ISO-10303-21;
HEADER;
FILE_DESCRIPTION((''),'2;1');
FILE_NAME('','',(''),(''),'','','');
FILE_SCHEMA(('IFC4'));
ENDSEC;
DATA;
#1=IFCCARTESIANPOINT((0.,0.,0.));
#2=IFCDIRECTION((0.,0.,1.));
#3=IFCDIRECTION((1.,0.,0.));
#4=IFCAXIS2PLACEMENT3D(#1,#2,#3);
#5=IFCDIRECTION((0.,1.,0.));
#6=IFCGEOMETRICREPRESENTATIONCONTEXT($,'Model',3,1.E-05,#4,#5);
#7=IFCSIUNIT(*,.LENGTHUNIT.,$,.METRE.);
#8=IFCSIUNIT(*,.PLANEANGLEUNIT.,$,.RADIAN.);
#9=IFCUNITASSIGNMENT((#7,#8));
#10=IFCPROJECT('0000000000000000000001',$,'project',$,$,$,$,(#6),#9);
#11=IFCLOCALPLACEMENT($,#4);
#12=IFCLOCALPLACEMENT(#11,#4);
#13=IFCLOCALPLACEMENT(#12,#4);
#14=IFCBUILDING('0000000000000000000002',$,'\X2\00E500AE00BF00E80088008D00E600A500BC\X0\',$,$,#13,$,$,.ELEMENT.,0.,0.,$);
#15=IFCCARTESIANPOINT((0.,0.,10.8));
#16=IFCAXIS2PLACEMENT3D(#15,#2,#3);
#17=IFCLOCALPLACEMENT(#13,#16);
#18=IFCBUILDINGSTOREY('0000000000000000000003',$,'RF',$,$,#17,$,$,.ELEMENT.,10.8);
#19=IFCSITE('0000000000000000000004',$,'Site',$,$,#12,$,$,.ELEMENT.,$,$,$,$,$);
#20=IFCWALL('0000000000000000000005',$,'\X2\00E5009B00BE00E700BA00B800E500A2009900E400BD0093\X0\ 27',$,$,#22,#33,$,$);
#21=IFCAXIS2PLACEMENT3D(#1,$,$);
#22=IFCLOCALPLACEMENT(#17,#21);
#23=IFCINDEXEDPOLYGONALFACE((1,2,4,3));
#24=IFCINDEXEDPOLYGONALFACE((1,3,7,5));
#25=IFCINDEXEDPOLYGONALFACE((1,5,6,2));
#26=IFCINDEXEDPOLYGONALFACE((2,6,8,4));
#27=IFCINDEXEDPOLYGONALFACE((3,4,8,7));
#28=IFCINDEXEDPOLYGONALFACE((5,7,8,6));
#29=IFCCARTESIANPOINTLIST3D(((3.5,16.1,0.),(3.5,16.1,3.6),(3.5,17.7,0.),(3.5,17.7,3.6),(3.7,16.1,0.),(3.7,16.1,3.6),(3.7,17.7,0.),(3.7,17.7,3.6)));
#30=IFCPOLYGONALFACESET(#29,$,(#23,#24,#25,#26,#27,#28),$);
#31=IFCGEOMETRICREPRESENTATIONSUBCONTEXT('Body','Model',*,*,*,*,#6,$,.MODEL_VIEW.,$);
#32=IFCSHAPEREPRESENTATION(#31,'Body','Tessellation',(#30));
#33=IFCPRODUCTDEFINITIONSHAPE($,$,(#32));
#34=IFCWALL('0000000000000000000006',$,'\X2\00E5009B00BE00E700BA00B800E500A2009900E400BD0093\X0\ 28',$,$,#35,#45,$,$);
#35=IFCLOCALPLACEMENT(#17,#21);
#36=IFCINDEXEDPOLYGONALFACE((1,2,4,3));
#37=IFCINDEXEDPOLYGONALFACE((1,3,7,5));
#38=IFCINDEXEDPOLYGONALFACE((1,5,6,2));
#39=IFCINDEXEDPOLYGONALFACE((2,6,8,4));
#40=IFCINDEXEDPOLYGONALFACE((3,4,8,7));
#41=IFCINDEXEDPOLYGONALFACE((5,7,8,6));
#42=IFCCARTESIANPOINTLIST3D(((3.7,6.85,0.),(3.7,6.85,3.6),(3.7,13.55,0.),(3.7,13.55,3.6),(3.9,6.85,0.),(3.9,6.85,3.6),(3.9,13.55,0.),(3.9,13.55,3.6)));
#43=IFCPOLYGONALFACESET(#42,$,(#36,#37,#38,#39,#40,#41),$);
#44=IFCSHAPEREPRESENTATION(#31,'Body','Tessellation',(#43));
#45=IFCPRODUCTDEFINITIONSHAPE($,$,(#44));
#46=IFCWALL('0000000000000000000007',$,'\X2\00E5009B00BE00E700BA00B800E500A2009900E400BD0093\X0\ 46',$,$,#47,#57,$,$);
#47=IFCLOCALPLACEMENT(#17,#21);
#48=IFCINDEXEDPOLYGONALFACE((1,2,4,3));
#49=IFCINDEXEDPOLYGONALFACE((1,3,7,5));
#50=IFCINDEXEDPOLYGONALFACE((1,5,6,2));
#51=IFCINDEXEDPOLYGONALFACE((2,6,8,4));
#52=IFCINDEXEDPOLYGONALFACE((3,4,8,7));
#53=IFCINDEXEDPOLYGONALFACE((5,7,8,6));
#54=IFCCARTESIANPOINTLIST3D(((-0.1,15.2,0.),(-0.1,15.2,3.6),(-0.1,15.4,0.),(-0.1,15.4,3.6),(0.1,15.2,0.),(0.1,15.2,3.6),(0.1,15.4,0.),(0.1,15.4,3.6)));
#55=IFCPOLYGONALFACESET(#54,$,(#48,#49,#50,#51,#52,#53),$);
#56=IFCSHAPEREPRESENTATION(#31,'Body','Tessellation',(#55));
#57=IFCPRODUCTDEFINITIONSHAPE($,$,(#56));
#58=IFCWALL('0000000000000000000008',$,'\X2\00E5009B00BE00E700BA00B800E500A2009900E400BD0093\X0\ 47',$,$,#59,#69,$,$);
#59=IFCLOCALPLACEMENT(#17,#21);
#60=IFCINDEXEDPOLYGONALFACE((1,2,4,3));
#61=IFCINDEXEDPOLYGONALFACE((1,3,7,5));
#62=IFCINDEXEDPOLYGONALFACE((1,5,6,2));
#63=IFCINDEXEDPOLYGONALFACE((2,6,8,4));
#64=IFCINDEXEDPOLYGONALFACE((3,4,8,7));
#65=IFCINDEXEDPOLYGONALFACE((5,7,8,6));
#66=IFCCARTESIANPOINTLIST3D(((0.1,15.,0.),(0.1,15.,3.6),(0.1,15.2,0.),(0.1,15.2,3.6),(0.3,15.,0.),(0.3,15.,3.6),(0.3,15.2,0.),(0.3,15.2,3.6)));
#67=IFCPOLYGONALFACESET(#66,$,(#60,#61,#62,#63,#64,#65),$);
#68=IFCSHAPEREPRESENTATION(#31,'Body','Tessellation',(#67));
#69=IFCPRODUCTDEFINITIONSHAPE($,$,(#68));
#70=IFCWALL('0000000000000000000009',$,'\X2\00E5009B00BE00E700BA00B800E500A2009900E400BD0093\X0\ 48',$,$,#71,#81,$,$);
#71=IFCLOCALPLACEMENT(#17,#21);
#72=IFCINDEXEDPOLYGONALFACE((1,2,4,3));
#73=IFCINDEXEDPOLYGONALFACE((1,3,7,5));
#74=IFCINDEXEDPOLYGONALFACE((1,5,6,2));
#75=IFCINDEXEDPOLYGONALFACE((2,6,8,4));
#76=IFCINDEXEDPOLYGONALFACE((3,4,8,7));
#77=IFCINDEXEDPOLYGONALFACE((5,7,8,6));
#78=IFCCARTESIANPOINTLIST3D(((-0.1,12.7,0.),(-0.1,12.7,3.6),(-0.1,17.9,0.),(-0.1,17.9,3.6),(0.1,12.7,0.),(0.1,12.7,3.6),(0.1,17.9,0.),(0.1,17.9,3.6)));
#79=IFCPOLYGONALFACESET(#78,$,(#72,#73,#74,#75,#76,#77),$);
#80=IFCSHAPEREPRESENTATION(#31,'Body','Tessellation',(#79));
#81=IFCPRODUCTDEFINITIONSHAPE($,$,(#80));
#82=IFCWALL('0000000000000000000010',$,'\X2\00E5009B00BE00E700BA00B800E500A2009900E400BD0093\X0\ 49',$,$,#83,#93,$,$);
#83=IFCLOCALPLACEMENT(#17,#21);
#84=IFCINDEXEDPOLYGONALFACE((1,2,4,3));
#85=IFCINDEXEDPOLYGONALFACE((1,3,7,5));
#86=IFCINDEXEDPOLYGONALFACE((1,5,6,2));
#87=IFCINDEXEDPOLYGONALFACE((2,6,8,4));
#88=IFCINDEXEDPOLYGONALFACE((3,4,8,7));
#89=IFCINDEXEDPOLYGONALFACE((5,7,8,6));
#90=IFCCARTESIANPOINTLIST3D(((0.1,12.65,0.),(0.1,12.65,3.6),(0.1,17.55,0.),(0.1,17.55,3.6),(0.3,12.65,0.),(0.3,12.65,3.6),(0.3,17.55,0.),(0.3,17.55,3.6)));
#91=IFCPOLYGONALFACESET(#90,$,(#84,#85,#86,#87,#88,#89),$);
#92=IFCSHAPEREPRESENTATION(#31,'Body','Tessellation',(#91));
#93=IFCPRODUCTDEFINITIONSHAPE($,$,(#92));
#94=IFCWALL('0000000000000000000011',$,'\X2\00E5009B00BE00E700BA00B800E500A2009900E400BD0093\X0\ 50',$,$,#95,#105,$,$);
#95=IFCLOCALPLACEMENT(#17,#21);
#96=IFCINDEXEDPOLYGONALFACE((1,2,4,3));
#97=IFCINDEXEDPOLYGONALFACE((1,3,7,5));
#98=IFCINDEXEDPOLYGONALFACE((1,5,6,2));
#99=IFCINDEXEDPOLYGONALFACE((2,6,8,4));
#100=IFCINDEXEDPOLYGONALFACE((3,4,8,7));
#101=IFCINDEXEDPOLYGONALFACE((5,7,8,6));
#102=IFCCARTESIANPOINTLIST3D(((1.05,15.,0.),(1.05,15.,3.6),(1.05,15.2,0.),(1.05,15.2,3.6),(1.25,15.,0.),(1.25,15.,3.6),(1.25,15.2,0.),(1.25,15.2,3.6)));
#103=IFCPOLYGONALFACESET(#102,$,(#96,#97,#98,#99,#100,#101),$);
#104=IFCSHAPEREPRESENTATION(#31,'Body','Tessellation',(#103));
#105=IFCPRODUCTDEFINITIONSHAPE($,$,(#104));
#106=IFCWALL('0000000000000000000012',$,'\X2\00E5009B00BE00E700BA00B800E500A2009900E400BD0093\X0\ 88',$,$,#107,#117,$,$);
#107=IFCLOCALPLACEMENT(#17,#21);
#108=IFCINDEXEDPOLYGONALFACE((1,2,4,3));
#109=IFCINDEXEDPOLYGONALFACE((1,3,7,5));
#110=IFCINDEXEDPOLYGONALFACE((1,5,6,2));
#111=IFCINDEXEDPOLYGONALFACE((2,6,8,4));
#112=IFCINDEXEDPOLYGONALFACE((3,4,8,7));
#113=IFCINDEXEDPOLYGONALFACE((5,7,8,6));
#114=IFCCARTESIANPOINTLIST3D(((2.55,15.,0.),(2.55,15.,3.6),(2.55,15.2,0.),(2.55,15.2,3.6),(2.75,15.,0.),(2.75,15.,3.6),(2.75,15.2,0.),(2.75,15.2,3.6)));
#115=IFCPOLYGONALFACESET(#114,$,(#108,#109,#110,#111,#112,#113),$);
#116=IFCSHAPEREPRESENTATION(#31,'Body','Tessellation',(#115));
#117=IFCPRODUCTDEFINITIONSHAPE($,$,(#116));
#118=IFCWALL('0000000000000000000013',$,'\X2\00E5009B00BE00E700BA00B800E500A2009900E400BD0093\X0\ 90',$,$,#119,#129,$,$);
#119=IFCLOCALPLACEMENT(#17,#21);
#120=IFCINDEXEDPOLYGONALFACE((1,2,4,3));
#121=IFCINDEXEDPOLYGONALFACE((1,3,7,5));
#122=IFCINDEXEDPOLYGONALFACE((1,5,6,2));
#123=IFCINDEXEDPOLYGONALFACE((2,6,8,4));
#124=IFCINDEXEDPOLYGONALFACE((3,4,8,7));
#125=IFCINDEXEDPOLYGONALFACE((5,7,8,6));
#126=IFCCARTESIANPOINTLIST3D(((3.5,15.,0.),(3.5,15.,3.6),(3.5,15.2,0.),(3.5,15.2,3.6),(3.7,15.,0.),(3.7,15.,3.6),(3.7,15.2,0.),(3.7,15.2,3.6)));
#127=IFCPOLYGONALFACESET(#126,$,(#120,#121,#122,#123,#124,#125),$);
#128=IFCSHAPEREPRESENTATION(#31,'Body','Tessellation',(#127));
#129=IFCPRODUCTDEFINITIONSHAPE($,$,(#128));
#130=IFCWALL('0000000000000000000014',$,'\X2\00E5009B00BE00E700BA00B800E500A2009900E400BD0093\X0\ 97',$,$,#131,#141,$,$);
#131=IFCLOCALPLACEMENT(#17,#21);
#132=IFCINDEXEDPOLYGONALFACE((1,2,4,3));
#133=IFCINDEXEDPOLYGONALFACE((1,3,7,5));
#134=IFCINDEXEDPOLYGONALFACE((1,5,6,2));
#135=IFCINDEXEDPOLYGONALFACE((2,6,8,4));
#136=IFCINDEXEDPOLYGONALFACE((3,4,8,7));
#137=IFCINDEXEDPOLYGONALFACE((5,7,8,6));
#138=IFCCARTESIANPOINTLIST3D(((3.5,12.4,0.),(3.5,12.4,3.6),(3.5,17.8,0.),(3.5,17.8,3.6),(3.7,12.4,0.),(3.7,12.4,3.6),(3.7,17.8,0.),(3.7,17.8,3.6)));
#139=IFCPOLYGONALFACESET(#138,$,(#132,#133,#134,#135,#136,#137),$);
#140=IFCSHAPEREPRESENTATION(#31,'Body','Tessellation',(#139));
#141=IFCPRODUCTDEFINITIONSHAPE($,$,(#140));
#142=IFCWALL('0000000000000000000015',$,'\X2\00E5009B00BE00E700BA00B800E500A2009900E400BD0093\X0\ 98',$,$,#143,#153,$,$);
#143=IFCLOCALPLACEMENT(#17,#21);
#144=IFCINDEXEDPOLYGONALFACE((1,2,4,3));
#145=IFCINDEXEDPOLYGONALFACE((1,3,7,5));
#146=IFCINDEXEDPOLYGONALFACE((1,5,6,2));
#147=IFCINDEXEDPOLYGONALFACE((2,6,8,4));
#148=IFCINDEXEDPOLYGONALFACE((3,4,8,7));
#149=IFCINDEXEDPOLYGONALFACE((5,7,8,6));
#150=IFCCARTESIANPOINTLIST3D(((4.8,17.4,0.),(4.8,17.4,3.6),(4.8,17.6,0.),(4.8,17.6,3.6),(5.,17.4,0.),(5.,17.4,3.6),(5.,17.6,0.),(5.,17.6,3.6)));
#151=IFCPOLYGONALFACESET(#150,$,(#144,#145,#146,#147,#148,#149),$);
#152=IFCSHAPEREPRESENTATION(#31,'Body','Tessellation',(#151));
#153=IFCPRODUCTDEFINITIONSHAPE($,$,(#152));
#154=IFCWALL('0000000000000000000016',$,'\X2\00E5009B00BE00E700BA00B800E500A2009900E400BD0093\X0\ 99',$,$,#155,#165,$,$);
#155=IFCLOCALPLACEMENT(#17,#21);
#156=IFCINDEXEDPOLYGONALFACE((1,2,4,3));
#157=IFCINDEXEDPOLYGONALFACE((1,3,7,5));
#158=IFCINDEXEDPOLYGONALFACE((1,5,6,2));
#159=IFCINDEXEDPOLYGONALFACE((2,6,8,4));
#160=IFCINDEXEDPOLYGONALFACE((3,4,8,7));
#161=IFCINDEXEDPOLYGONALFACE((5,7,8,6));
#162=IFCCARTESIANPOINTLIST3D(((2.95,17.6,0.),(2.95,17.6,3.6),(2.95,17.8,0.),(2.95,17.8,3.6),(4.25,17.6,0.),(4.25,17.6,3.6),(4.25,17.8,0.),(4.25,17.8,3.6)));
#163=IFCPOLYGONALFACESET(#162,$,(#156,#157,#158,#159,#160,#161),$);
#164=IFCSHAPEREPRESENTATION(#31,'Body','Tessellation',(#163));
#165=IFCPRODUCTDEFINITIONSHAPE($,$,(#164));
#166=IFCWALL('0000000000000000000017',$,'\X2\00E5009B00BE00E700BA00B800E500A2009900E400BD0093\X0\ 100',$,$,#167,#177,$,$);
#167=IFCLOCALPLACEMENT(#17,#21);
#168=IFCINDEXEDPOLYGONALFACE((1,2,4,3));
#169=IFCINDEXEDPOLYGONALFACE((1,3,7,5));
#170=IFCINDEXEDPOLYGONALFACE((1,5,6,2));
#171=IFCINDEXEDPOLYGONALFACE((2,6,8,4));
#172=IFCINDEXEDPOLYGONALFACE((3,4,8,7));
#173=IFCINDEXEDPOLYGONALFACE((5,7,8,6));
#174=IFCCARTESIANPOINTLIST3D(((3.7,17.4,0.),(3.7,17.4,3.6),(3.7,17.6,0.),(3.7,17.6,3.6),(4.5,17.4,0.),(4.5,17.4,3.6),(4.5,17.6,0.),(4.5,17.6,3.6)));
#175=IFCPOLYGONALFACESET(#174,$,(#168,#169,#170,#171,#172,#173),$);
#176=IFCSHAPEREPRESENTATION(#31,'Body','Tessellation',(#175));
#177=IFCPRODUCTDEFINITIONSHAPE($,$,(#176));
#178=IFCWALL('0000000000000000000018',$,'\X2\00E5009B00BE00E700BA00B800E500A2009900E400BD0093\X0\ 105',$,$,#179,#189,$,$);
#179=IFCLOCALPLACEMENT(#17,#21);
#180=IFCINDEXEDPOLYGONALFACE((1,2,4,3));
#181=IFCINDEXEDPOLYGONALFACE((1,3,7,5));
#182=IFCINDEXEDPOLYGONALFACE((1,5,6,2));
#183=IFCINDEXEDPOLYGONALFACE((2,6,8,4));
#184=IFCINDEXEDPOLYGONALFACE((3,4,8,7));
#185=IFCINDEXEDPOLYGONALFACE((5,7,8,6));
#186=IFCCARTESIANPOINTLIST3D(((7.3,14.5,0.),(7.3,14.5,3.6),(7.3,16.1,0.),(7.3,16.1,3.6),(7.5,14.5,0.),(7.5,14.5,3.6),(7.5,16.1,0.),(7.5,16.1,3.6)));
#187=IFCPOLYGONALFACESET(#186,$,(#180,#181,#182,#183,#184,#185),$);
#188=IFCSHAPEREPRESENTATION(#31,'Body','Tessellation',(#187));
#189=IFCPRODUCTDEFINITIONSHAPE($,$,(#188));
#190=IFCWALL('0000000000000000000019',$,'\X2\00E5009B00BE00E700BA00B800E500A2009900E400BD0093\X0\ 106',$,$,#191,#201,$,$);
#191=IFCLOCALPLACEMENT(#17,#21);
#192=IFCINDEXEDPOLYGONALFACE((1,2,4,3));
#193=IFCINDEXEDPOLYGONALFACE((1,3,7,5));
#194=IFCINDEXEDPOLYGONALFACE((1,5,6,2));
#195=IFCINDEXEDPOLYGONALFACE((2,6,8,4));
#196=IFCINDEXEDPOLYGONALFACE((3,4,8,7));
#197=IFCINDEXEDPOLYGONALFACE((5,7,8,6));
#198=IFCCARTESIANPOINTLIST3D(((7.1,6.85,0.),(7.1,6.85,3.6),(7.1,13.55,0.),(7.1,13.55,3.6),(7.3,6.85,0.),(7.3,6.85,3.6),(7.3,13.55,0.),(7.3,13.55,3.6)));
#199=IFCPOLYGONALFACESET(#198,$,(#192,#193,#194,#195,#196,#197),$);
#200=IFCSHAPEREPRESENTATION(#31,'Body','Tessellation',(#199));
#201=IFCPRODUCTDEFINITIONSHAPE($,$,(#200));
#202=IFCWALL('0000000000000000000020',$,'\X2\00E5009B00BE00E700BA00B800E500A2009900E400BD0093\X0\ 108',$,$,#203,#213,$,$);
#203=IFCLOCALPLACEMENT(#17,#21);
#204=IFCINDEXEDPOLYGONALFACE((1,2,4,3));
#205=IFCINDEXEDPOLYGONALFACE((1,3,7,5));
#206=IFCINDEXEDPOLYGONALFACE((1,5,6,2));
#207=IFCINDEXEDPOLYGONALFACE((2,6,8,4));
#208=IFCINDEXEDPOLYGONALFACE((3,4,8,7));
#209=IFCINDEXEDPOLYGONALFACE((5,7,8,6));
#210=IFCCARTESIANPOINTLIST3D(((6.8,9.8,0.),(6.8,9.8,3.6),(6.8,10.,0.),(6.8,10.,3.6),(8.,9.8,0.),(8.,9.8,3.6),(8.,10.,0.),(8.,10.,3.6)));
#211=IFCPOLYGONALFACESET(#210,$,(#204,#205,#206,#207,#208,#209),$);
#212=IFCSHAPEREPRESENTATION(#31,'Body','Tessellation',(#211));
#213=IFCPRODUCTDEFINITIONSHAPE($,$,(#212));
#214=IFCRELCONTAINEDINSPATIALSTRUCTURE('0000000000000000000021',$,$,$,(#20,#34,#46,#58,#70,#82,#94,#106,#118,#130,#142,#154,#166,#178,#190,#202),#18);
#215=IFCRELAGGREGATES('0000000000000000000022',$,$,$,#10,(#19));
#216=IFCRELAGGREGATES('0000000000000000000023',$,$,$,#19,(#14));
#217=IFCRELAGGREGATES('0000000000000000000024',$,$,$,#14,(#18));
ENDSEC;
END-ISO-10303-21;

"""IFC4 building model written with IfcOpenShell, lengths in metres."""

from ifc_helpers import new_model, si_unit, direction, frame, frame_2d, origin_with_axes, place, context, subcontext, project, spatial, rectangle, extrude, element, save


model = new_model("IFC4")

# Units and contexts
model_context = context("Model", 3, precision=1e-05, world=origin_with_axes(), true_north=direction((0.0, 1.0, 0.0)))
body_context = subcontext(model_context, "Body", "Model", "MODEL_VIEW")
ifc_project = project(units=[si_unit("LENGTHUNIT", "METRE"), si_unit("PLANEANGLEUNIT", "RADIAN")], contexts=[model_context])

# Site, building, storey
placement = place(None, origin_with_axes())
site_placement = place(placement, origin_with_axes())
site = spatial("IfcSite", under=ifc_project, at=site_placement, Name="Site", CompositionType="ELEMENT")
building_placement = place(site_placement, origin_with_axes())
building = spatial("IfcBuilding", under=site, at=building_placement, Name="å®¿è\u0088\u008dæ¥¼", CompositionType="ELEMENT", ElevationOfRefHeight=0.0, ElevationOfTerrain=0.0)
storey_placement = place(building_placement, frame((0.0, 0.0, 10.8), z_axis=(0.0, 0.0, 1.0), x_axis=(1.0, 0.0, 0.0)))
storey = spatial("IfcBuildingStorey", under=building, at=storey_placement, Name="RF", CompositionType="ELEMENT", Elevation=10.8)

# Walls
wall_1_placement = place(storey_placement, frame((3.6, 16.9, 0.0), z_axis=(0.0, 0.0, 1.0), x_axis=(0.0, -1.0, 0.0)))
element("IfcWall", 1, at=wall_1_placement, inside=storey, Name="å\u009b¾çº¸å¢\u0099ä½\u0093 27", context=body_context, shape_type="SweptSolid", body=[
    extrude(rectangle(XDim=1.6, YDim=0.2, at=frame_2d((0.0, 0.0), x_axis=(1.0, 0.0, 0.0))), frame((0.0, 0.0, 0.0), z_axis=(0.0, 0.0, 1.0)), (0.0, 0.0, 1.0), 3.6),
])
wall_2_placement = place(storey_placement, frame((3.8, 10.2, 0.0), z_axis=(0.0, 0.0, 1.0), x_axis=(0.0, 1.0, 0.0)))
element("IfcWall", 2, at=wall_2_placement, inside=storey, Name="å\u009b¾çº¸å¢\u0099ä½\u0093 28", context=body_context, shape_type="SweptSolid", body=[
    extrude(rectangle(XDim=6.7, YDim=0.2, at=frame_2d((0.0, 0.0), x_axis=(1.0, 0.0, 0.0))), frame((0.0, 0.0, 0.0), z_axis=(0.0, 0.0, 1.0)), (0.0, 0.0, 1.0), 3.6),
])
for number, where, z_axis, x_axis, name in (
    (3, (0.0, 15.3, 0.0), (0.0, 0.0, 1.0), (1.0, 0.0, 0.0), "å\u009b¾çº¸å¢\u0099ä½\u0093 46"),
    (4, (0.2, 15.1, 0.0), (0.0, 0.0, 1.0), (0.0, 1.0, 0.0), "å\u009b¾çº¸å¢\u0099ä½\u0093 47"),
):
    element("IfcWall", number, at=place(storey_placement, frame(where, z_axis=z_axis, x_axis=x_axis)), inside=storey, Name=name, context=body_context, shape_type="SweptSolid", body=[
        extrude(rectangle(XDim=0.2, YDim=0.2, at=frame_2d((0.0, 0.0), x_axis=(1.0, 0.0, 0.0))), frame((0.0, 0.0, 0.0), z_axis=(0.0, 0.0, 1.0)), (0.0, 0.0, 1.0), 3.6),
    ])
wall_3_placement = place(storey_placement, frame((0.0, 15.3, 0.0), z_axis=(0.0, 0.0, 1.0), x_axis=(0.0, -1.0, 0.0)))
element("IfcWall", 5, at=wall_3_placement, inside=storey, Name="å\u009b¾çº¸å¢\u0099ä½\u0093 48", context=body_context, shape_type="SweptSolid", body=[
    extrude(rectangle(XDim=5.2, YDim=0.2, at=frame_2d((0.0, 0.0), x_axis=(1.0, 0.0, 0.0))), frame((0.0, 0.0, 0.0), z_axis=(0.0, 0.0, 1.0)), (0.0, 0.0, 1.0), 3.6),
])
wall_4_placement = place(storey_placement, frame((0.2, 15.1, 0.0), z_axis=(0.0, 0.0, 1.0), x_axis=(0.0, -1.0, 0.0)))
element("IfcWall", 6, at=wall_4_placement, inside=storey, Name="å\u009b¾çº¸å¢\u0099ä½\u0093 49", context=body_context, shape_type="SweptSolid", body=[
    extrude(rectangle(XDim=4.9, YDim=0.2, at=frame_2d((0.0, 0.0), x_axis=(1.0, 0.0, 0.0))), frame((0.0, 0.0, 0.0), z_axis=(0.0, 0.0, 1.0)), (0.0, 0.0, 1.0), 3.6),
])
for number, where, z_axis, x_axis, name in (
    (7, (1.15, 15.1, 0.0), (0.0, 0.0, 1.0), (0.0, 1.0, 0.0), "å\u009b¾çº¸å¢\u0099ä½\u0093 50"),
    (8, (2.65, 15.1, 0.0), (0.0, 0.0, 1.0), (0.0, 1.0, 0.0), "å\u009b¾çº¸å¢\u0099ä½\u0093 88"),
    (9, (3.6, 15.1, 0.0), (0.0, 0.0, 1.0), (0.0, 1.0, 0.0), "å\u009b¾çº¸å¢\u0099ä½\u0093 90"),
):
    element("IfcWall", number, at=place(storey_placement, frame(where, z_axis=z_axis, x_axis=x_axis)), inside=storey, Name=name, context=body_context, shape_type="SweptSolid", body=[
        extrude(rectangle(XDim=0.2, YDim=0.2, at=frame_2d((0.0, 0.0), x_axis=(1.0, 0.0, 0.0))), frame((0.0, 0.0, 0.0), z_axis=(0.0, 0.0, 1.0)), (0.0, 0.0, 1.0), 3.6),
    ])
wall_5_placement = place(storey_placement, frame((3.6, 15.1, 0.0), z_axis=(0.0, 0.0, 1.0), x_axis=(0.0, -1.0, 0.0)))
element("IfcWall", 10, at=wall_5_placement, inside=storey, Name="å\u009b¾çº¸å¢\u0099ä½\u0093 97", context=body_context, shape_type="SweptSolid", body=[
    extrude(rectangle(XDim=5.4, YDim=0.2, at=frame_2d((0.0, 0.0), x_axis=(1.0, 0.0, 0.0))), frame((0.0, 0.0, 0.0), z_axis=(0.0, 0.0, 1.0)), (0.0, 0.0, 1.0), 3.6),
])
wall_6_placement = place(storey_placement, frame((4.9, 17.5, 0.0), z_axis=(0.0, 0.0, 1.0), x_axis=(0.0, 1.0, 0.0)))
element("IfcWall", 11, at=wall_6_placement, inside=storey, Name="å\u009b¾çº¸å¢\u0099ä½\u0093 98", context=body_context, shape_type="SweptSolid", body=[
    extrude(rectangle(XDim=0.2, YDim=0.2, at=frame_2d((0.0, 0.0), x_axis=(1.0, 0.0, 0.0))), frame((0.0, 0.0, 0.0), z_axis=(0.0, 0.0, 1.0)), (0.0, 0.0, 1.0), 3.6),
])
wall_7_placement = place(storey_placement, frame((3.6, 17.7, 0.0), z_axis=(0.0, 0.0, 1.0), x_axis=(1.0, 0.0, 0.0)))
element("IfcWall", 12, at=wall_7_placement, inside=storey, Name="å\u009b¾çº¸å¢\u0099ä½\u0093 99", context=body_context, shape_type="SweptSolid", body=[
    extrude(rectangle(XDim=1.3, YDim=0.2, at=frame_2d((0.0, 0.0), x_axis=(1.0, 0.0, 0.0))), frame((0.0, 0.0, 0.0), z_axis=(0.0, 0.0, 1.0)), (0.0, 0.0, 1.0), 3.6),
])
wall_8_placement = place(storey_placement, frame((4.1, 17.5, 0.0), z_axis=(0.0, 0.0, 1.0), x_axis=(1.0, 0.0, 0.0)))
element("IfcWall", 13, at=wall_8_placement, inside=storey, Name="å\u009b¾çº¸å¢\u0099ä½\u0093 100", context=body_context, shape_type="SweptSolid", body=[
    extrude(rectangle(XDim=0.8, YDim=0.2, at=frame_2d((0.0, 0.0), x_axis=(1.0, 0.0, 0.0))), frame((0.0, 0.0, 0.0), z_axis=(0.0, 0.0, 1.0)), (0.0, 0.0, 1.0), 3.6),
])
wall_9_placement = place(storey_placement, frame((7.4, 15.3, 0.0), z_axis=(0.0, 0.0, 1.0), x_axis=(0.0, 1.0, 0.0)))
element("IfcWall", 14, at=wall_9_placement, inside=storey, Name="å\u009b¾çº¸å¢\u0099ä½\u0093 105", context=body_context, shape_type="SweptSolid", body=[
    extrude(rectangle(XDim=1.6, YDim=0.2, at=frame_2d((0.0, 0.0), x_axis=(1.0, 0.0, 0.0))), frame((0.0, 0.0, 0.0), z_axis=(0.0, 0.0, 1.0)), (0.0, 0.0, 1.0), 3.6),
])
wall_10_placement = place(storey_placement, frame((7.2, 10.2, 0.0), z_axis=(0.0, 0.0, 1.0), x_axis=(0.0, 1.0, 0.0)))
element("IfcWall", 15, at=wall_10_placement, inside=storey, Name="å\u009b¾çº¸å¢\u0099ä½\u0093 106", context=body_context, shape_type="SweptSolid", body=[
    extrude(rectangle(XDim=6.7, YDim=0.2, at=frame_2d((0.0, 0.0), x_axis=(1.0, 0.0, 0.0))), frame((0.0, 0.0, 0.0), z_axis=(0.0, 0.0, 1.0)), (0.0, 0.0, 1.0), 3.6),
])
wall_11_placement = place(storey_placement, frame((7.4, 9.9, 0.0), z_axis=(0.0, 0.0, 1.0), x_axis=(1.0, 0.0, 0.0)))
element("IfcWall", 16, at=wall_11_placement, inside=storey, Name="å\u009b¾çº¸å¢\u0099ä½\u0093 108", context=body_context, shape_type="SweptSolid", body=[
    extrude(rectangle(XDim=1.2, YDim=0.2, at=frame_2d((0.0, 0.0), x_axis=(1.0, 0.0, 0.0))), frame((0.0, 0.0, 0.0), z_axis=(0.0, 0.0, 1.0)), (0.0, 0.0, 1.0), 3.6),
])

save(model, "model.ifc")
